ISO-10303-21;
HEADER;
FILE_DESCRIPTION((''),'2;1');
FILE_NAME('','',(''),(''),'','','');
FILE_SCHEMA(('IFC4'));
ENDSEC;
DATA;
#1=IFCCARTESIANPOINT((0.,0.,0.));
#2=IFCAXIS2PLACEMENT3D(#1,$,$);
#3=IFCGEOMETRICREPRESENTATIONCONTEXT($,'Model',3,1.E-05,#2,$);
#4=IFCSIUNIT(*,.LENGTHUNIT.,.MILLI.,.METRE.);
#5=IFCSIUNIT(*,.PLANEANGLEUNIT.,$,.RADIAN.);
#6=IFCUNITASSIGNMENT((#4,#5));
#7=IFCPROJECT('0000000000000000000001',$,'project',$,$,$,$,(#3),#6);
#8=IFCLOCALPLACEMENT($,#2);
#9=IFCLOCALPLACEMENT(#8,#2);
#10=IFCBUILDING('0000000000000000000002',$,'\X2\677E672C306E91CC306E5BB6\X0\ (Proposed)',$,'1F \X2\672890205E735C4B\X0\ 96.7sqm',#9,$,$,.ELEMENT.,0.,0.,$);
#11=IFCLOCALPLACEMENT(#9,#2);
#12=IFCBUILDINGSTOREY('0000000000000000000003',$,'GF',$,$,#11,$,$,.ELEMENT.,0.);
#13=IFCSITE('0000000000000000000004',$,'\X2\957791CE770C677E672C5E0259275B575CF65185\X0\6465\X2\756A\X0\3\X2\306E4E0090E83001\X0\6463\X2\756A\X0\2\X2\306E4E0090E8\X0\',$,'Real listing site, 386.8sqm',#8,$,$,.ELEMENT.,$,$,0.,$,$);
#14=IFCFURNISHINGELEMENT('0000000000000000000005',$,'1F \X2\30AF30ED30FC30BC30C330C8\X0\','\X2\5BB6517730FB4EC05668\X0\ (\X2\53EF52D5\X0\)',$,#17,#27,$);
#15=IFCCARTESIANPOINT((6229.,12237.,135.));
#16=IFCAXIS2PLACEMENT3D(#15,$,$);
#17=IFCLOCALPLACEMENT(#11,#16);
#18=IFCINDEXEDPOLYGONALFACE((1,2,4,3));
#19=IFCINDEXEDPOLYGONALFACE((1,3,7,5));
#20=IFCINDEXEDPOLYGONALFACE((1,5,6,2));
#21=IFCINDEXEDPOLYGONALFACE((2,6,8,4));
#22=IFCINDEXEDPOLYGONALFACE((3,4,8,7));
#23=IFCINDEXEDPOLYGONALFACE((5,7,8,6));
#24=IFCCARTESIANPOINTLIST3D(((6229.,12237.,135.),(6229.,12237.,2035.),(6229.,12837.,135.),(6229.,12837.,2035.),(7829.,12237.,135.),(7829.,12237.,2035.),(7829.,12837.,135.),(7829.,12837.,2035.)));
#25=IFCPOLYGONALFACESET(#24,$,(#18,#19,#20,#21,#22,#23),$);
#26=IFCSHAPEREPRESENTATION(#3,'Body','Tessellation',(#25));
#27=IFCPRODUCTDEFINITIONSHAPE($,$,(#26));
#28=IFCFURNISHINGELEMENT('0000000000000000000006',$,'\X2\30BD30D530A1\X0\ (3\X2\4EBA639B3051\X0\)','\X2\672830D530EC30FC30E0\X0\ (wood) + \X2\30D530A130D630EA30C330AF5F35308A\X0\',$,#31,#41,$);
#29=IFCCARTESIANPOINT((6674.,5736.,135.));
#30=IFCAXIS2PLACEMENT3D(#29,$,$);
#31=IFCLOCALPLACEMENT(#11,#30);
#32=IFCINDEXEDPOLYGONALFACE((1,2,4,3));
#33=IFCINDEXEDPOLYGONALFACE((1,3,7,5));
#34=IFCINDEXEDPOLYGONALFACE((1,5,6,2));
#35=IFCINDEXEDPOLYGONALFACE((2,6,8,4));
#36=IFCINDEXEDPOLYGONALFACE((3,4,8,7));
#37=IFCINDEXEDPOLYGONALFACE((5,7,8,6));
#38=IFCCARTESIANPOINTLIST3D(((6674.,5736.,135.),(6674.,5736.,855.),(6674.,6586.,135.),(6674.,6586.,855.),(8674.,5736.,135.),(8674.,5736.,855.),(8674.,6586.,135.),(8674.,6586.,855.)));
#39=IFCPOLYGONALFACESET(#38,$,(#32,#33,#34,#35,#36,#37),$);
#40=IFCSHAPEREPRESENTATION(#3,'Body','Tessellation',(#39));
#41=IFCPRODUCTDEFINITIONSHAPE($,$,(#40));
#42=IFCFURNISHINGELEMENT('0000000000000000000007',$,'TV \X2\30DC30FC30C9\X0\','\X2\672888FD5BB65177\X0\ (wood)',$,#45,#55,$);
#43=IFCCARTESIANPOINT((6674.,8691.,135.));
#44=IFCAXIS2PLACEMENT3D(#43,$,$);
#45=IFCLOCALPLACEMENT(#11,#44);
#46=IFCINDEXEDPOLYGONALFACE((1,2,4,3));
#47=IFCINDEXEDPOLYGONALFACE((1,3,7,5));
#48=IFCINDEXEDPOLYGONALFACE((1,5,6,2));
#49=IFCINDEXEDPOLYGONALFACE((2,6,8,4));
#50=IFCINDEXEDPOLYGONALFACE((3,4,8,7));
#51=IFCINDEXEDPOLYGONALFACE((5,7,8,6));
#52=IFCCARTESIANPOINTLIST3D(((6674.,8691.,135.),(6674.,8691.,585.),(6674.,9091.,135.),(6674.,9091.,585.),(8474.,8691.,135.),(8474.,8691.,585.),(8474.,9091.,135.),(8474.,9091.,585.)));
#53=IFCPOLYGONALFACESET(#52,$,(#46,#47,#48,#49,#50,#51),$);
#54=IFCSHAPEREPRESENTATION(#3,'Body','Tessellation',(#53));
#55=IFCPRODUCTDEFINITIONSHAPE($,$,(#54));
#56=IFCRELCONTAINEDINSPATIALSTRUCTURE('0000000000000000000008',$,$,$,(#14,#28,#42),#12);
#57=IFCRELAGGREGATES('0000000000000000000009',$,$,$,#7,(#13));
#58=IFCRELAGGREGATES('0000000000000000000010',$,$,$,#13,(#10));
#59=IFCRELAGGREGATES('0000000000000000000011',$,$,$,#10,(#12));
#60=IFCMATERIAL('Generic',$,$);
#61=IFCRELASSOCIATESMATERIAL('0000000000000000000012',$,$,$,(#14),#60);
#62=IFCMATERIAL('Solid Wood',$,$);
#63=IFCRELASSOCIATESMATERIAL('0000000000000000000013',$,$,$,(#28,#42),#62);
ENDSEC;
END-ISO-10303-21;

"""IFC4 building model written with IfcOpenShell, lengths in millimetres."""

from ifc_helpers import new_model, si_unit, frame, frame_2d, origin, place, context, project, spatial, rectangle, extrude, material, element, save


model = new_model("IFC4")

# Units and contexts
model_context = context("Model", 3, precision=1e-05, world=origin())
ifc_project = project(units=[si_unit("LENGTHUNIT", "METRE", prefix="MILLI"), si_unit("PLANEANGLEUNIT", "RADIAN")], contexts=[model_context])

# Site, building, storey
site_placement = place(None, origin())
site = spatial("IfcSite", under=ifc_project, at=site_placement, Name="長野県松本市大字島内6465番3の一部、6463番2の一部", ObjectType="Real listing site, 386.8sqm", CompositionType="ELEMENT", RefElevation=0.0)
building_placement = place(site_placement, origin())
building = spatial("IfcBuilding", under=site, at=building_placement, Name="松本の里の家 (Proposed)", ObjectType="1F 木造平屋 96.7sqm", CompositionType="ELEMENT", ElevationOfRefHeight=0.0, ElevationOfTerrain=0.0)
storey_placement = place(building_placement, origin())
storey = spatial("IfcBuildingStorey", under=building, at=storey_placement, Name="GF", CompositionType="ELEMENT", Elevation=0.0)

# Shared definitions
ifc_material_1 = material(Name="Solid Wood")

# Shared definitions
ifc_material_2 = material(Name="Generic")

# Furnishing elements
furnishing_1_placement = place(storey_placement, frame((6229.0, 12237.0, 135.0)))
element("IfcFurnishingElement", 1, at=furnishing_1_placement, inside=storey, material=ifc_material_2, Name="1F クローゼット", Description="家具・什器 (可動)", context=model_context, shape_type="SweptSolid", body=[
    extrude(rectangle(XDim=1600.0, YDim=600.0, at=frame_2d((800.0, 300.0))), frame((6229.0, 12237.0, 135.0)), (0.0, 0.0, 1.0), 1900.0),
])
furnishing_2_placement = place(storey_placement, frame((6674.0, 5736.0, 135.0)))
element("IfcFurnishingElement", 2, at=furnishing_2_placement, inside=storey, material=ifc_material_1, Name="ソファ (3人掛け)", Description="木フレーム (wood) + ファブリック張り", context=model_context, shape_type="SweptSolid", body=[
    extrude(rectangle(XDim=2000.0, YDim=850.0, at=frame_2d((1000.0, 425.0))), frame((6674.0, 5736.0, 135.0)), (0.0, 0.0, 1.0), 720.0),
])
furnishing_3_placement = place(storey_placement, frame((6674.0, 8691.0, 135.0)))
element("IfcFurnishingElement", 3, at=furnishing_3_placement, inside=storey, material=ifc_material_1, Name="TV ボード", Description="木製家具 (wood)", context=model_context, shape_type="SweptSolid", body=[
    extrude(rectangle(XDim=1800.0, YDim=400.0, at=frame_2d((900.0, 200.0))), frame((6674.0, 8691.0, 135.0)), (0.0, 0.0, 1.0), 450.0),
])

save(model, "model.ifc")
